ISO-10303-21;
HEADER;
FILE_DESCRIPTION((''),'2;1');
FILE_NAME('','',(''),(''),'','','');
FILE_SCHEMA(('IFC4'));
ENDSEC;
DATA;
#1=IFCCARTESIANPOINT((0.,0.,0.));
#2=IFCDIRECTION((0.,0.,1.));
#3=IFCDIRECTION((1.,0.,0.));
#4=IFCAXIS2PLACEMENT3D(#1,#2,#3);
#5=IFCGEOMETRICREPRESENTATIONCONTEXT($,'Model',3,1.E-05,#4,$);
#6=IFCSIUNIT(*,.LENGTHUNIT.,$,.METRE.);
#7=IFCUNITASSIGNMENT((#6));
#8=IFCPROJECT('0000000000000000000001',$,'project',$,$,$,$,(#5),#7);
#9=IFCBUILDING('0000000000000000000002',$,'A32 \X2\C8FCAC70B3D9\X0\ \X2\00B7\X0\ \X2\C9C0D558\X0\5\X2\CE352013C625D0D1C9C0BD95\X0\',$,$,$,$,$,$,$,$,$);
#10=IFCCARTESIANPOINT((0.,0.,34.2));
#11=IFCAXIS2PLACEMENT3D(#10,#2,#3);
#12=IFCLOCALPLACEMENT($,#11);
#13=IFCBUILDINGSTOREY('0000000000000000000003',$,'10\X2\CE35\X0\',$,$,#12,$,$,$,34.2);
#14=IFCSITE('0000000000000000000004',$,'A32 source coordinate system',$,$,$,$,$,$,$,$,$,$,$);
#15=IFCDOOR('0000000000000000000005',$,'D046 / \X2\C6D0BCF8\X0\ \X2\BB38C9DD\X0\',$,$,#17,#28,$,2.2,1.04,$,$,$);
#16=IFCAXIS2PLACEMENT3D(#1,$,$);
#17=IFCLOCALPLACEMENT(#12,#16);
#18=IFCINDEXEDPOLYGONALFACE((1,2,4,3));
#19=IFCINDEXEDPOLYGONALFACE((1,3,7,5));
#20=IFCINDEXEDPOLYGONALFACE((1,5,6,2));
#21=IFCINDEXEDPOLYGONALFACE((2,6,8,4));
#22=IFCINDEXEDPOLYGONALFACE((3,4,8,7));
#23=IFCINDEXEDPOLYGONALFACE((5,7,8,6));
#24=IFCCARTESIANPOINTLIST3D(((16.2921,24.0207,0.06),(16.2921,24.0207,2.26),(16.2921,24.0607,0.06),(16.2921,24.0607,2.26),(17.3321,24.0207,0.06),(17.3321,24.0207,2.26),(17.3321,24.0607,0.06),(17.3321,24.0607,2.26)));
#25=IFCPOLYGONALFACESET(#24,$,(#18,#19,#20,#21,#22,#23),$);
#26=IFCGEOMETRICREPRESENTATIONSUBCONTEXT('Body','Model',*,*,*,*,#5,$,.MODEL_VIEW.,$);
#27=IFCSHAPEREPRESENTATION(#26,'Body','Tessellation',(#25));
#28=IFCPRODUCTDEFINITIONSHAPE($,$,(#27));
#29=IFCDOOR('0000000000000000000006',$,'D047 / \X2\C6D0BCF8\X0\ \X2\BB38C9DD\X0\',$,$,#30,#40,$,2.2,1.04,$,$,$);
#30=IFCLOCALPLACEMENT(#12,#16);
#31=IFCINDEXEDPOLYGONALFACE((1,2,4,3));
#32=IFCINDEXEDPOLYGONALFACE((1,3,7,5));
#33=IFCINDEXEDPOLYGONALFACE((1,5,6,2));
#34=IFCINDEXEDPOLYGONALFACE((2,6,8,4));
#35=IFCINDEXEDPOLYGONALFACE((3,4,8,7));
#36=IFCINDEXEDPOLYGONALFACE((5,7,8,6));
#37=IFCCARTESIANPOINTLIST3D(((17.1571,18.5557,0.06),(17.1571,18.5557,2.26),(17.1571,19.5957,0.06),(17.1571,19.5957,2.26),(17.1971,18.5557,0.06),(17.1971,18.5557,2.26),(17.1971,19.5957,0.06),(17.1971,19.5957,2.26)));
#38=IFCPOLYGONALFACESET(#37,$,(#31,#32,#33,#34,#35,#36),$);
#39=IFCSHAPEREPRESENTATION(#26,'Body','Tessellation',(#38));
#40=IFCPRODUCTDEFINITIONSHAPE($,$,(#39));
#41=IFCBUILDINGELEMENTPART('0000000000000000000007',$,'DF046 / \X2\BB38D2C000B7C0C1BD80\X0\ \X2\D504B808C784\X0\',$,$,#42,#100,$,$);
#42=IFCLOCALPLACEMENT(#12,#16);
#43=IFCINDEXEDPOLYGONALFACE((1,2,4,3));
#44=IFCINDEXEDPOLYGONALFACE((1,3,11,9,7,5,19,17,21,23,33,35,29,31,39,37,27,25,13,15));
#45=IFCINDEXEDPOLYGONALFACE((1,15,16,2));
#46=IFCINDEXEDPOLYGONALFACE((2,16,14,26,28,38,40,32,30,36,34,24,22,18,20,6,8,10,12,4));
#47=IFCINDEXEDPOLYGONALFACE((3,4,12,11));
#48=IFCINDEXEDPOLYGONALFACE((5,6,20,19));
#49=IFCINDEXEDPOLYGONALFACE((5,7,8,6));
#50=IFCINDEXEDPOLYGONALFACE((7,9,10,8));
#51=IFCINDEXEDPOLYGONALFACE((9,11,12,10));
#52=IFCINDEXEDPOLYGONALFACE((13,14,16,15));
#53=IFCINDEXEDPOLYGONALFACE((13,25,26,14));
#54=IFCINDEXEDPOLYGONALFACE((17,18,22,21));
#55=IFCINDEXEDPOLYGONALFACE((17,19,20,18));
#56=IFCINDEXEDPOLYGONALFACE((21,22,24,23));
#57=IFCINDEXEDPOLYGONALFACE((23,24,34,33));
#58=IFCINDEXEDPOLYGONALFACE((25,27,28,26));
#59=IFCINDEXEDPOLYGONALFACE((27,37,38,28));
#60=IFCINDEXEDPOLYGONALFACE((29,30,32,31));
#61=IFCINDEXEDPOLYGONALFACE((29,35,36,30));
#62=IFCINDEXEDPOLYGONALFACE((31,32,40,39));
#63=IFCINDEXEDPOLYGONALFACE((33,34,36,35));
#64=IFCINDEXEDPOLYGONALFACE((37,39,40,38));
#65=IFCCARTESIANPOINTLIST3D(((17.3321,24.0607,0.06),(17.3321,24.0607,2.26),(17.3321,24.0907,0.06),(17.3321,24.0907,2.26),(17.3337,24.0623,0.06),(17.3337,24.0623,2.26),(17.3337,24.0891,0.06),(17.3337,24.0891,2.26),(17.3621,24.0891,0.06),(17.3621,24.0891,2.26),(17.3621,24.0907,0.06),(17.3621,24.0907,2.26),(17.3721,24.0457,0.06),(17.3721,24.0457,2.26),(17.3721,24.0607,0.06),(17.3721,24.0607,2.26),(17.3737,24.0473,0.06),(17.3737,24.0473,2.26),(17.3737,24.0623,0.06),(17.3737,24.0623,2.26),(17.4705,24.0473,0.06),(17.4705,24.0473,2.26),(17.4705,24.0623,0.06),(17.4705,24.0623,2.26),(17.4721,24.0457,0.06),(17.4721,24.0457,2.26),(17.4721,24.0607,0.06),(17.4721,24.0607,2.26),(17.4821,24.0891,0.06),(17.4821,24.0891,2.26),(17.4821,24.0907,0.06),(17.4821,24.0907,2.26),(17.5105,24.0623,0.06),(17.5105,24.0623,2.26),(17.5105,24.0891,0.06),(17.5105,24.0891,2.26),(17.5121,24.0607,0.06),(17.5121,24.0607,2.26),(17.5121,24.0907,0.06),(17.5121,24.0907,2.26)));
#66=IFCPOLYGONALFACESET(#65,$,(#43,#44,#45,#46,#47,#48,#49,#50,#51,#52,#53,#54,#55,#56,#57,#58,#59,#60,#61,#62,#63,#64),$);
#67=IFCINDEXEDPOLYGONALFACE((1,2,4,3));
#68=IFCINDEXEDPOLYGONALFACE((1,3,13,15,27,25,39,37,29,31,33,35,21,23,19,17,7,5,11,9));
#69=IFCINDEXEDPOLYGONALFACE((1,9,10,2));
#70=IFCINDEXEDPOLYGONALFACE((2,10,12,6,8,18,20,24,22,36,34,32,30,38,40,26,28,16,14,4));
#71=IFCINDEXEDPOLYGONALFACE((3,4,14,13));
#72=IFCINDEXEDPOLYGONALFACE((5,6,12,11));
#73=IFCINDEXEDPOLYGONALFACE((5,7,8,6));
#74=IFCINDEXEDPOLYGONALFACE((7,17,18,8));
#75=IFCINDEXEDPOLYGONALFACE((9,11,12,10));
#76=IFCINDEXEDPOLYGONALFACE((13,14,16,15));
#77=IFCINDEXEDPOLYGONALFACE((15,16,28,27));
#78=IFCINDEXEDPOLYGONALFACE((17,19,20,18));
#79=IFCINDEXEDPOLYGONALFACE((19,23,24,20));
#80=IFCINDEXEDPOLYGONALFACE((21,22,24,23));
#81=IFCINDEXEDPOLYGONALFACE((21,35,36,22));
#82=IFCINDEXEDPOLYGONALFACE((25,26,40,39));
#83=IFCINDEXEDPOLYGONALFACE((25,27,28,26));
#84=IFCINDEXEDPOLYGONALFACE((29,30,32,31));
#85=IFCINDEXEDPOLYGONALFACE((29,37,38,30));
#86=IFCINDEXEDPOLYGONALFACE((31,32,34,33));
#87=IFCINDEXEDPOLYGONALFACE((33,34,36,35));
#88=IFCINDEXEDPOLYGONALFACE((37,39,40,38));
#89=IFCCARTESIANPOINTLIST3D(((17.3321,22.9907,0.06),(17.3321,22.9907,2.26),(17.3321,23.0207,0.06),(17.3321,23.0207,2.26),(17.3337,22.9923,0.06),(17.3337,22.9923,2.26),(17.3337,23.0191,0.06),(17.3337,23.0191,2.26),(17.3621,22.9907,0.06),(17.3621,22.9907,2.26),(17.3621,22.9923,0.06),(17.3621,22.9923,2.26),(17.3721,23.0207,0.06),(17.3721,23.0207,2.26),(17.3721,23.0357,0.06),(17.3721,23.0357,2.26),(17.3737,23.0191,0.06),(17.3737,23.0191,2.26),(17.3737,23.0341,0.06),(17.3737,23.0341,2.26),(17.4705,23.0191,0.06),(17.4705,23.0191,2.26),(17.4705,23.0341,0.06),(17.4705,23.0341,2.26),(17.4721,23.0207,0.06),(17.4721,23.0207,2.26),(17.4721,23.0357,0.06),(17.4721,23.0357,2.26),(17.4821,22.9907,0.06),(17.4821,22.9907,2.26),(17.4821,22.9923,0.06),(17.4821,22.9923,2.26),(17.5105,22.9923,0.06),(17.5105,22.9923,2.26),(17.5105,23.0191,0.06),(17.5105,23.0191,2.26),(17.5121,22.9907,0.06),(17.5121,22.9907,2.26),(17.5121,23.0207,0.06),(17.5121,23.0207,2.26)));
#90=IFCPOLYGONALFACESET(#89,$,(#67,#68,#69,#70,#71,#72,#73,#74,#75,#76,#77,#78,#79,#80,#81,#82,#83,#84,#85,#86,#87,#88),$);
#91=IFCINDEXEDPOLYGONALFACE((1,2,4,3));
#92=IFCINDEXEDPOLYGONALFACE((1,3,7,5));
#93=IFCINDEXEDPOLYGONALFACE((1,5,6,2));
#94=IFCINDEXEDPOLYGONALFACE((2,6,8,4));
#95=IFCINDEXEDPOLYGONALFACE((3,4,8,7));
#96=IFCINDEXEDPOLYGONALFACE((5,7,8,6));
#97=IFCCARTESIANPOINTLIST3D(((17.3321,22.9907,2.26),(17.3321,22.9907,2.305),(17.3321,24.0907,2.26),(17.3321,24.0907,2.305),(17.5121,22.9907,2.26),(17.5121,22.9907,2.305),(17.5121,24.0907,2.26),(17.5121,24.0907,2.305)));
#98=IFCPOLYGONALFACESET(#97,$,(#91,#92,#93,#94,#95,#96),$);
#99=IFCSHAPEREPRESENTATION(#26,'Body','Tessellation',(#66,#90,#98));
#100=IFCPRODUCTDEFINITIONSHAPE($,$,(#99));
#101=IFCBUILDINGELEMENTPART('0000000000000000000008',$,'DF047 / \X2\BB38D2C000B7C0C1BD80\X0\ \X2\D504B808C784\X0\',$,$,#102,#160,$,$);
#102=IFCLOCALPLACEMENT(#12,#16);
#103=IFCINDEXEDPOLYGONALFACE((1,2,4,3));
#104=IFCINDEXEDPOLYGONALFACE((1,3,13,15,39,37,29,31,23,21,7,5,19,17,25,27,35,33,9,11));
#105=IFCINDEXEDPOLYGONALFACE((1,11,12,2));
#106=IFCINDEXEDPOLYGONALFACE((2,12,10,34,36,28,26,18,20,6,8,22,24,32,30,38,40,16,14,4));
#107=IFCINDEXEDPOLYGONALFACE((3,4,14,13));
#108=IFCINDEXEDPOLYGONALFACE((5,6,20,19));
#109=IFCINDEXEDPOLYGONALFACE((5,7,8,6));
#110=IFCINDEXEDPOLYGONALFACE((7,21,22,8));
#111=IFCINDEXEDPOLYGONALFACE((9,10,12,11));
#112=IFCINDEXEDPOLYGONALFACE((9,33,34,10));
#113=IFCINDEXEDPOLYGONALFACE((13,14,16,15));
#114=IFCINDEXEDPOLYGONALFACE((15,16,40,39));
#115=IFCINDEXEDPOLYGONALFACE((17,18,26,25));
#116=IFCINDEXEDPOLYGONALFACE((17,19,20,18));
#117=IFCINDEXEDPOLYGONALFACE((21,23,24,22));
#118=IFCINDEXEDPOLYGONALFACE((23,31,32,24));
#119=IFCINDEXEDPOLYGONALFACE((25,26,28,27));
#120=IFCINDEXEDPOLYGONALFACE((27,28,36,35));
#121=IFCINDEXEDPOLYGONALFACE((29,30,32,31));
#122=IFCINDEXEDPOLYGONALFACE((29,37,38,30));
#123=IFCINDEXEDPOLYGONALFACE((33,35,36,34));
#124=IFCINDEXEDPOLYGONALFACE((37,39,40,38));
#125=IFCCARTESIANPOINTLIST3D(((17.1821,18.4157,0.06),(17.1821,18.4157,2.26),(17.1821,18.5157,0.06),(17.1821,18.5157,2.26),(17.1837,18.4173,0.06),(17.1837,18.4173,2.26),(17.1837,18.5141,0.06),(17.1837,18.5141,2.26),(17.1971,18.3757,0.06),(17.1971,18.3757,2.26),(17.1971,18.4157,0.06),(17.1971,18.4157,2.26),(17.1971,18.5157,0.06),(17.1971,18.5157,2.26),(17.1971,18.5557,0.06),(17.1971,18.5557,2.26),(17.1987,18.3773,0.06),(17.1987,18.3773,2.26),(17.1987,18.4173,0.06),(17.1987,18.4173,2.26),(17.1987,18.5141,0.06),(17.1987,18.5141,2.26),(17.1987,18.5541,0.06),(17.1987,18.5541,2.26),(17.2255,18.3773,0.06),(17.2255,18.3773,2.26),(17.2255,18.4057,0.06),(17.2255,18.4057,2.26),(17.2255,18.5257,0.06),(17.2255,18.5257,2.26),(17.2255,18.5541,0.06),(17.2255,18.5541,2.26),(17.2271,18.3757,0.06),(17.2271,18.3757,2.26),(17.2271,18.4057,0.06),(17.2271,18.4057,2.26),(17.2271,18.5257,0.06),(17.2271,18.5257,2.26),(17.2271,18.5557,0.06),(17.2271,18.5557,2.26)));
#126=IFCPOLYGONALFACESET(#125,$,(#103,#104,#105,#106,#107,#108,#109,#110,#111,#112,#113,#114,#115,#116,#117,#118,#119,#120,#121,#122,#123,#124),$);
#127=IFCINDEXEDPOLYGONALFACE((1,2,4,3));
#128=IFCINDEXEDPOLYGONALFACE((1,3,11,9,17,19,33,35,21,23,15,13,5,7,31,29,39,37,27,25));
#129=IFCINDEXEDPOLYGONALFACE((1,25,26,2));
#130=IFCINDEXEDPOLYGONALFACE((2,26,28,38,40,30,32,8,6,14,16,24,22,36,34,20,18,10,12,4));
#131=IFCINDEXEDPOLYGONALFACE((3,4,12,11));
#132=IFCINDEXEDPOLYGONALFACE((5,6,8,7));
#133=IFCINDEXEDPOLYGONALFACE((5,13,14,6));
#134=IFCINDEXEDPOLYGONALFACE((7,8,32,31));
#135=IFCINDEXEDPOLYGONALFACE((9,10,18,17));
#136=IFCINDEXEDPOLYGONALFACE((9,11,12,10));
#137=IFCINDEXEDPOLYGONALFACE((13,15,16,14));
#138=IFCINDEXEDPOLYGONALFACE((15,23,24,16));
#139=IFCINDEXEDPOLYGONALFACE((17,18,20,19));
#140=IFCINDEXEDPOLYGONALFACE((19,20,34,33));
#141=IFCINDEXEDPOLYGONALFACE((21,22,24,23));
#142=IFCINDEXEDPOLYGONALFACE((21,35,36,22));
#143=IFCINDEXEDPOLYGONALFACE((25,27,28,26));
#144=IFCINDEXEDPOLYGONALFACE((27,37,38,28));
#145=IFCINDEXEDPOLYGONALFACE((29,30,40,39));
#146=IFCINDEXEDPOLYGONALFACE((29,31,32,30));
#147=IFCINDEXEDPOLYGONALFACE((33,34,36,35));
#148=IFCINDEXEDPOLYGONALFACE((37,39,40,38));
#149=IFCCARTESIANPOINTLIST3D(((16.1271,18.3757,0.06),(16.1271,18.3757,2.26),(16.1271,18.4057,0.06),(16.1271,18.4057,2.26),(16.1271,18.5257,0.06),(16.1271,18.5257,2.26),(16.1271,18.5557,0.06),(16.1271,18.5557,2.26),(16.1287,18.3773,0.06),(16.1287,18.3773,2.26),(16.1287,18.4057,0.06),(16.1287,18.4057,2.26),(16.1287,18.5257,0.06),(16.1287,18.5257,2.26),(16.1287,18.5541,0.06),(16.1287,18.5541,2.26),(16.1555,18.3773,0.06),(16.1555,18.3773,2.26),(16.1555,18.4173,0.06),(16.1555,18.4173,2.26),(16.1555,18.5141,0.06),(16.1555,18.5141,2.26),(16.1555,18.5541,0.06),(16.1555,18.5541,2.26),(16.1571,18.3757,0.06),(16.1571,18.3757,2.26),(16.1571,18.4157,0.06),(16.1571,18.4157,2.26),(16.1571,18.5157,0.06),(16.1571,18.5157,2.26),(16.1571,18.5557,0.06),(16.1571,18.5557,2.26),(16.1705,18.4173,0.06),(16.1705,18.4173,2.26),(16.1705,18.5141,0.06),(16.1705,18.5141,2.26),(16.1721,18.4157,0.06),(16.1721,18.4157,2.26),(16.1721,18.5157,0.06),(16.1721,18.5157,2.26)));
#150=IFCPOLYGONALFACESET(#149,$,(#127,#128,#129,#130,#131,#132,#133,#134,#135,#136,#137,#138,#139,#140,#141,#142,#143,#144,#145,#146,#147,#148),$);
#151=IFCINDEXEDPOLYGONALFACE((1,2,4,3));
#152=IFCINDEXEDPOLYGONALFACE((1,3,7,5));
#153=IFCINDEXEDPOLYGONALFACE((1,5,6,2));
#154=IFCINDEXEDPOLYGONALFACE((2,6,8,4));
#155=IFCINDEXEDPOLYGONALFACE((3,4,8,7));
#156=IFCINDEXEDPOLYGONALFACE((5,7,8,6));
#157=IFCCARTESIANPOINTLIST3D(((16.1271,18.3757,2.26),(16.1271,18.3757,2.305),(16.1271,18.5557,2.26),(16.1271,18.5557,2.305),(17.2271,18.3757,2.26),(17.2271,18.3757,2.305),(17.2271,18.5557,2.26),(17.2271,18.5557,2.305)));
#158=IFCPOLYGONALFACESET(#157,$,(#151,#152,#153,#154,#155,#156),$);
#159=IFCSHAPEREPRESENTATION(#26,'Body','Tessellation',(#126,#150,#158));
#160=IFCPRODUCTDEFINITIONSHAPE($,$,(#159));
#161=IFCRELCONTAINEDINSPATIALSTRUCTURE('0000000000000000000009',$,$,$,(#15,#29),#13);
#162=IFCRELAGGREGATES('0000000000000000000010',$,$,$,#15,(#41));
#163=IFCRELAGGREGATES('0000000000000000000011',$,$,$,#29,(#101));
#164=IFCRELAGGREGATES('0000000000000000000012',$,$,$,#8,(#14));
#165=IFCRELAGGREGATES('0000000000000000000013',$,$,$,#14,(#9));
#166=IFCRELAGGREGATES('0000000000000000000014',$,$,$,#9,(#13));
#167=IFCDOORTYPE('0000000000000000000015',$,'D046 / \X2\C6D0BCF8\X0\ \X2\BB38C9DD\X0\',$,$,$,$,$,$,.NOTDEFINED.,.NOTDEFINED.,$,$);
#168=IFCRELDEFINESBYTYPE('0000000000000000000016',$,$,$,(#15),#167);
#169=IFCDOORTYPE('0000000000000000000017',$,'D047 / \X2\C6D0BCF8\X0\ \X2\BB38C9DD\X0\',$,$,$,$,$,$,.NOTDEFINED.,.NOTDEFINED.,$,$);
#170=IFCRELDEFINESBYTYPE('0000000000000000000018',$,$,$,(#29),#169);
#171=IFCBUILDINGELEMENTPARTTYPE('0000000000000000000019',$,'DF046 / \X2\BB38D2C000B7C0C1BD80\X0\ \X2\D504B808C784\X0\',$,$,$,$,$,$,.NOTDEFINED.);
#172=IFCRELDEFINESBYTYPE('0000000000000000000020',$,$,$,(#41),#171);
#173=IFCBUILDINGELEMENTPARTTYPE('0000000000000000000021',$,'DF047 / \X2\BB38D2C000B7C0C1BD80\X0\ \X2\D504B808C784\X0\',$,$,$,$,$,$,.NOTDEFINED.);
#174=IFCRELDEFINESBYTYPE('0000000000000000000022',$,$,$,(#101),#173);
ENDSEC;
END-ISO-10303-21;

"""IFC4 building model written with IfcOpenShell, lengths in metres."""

from ifc_helpers import new_model, si_unit, frame, origin, origin_with_axes, place, context, subcontext, project, spatial, polyline, outline, extrude, source, transform, mapped, type_object, type_shapes, element, aggregate, save


model = new_model("IFC4")

# Units and contexts
model_context = context("Model", 3, precision=1e-05, world=origin_with_axes())
body_context = subcontext(model_context, "Body", "Model", "MODEL_VIEW")
ifc_project = project(units=[si_unit("LENGTHUNIT", "METRE")], contexts=[model_context])

# Site, building, storey
storey_placement = place(None, frame((0.0, 0.0, 34.2), z_axis=(0.0, 0.0, 1.0), x_axis=(1.0, 0.0, 0.0)))
site = spatial("IfcSite", under=ifc_project, Name="A32 source coordinate system")
building = spatial("IfcBuilding", under=site, Name="A32 주거동 · 지하5층–옥탑지붕")
storey = spatial("IfcBuildingStorey", under=building, at=storey_placement, Name="10층", Elevation=34.2)

# Doors
door_type_1 = type_object("IfcDoorType", Name="D046 / 원본 문짝", OperationType="NOTDEFINED", PredefinedType="NOTDEFINED")
shared_shape_1 = source(origin(), body_context, "Body", "SweptSolid", [
    extrude(outline(polyline([(17.3321, 24.0607), (17.3321, 24.0207), (16.2921, 24.0207), (16.2921, 24.0607), (17.3321, 24.0607)])), frame((0.0, 0.0, 0.06)), (0.0, 0.0, 1.0), 2.2),
])
type_shapes(door_type_1, [shared_shape_1])
door_1_placement = place(storey_placement, origin_with_axes())
door_1 = element("IfcDoor", 1, at=door_1_placement, inside=storey, type_object=door_type_1, Name="D046 / 원본 문짝", OverallHeight=2.2, OverallWidth=1.04, context=body_context, shape_type="MappedRepresentation", body=[
    mapped(shared_shape_1, transform((0.0, 0.0, 0.0), scale=1.0)),
])
door_type_2 = type_object("IfcDoorType", Name="D047 / 원본 문짝", OperationType="NOTDEFINED", PredefinedType="NOTDEFINED")
shared_shape_2 = source(origin(), body_context, "Body", "SweptSolid", [
    extrude(outline(polyline([(17.1971, 18.5557), (17.1571, 18.5557), (17.1571, 19.5957), (17.1971, 19.5957), (17.1971, 18.5557)])), frame((0.0, 0.0, 0.06)), (0.0, 0.0, 1.0), 2.2),
])
type_shapes(door_type_2, [shared_shape_2])
door_2_placement = place(storey_placement, origin_with_axes())
door_2 = element("IfcDoor", 2, at=door_2_placement, inside=storey, type_object=door_type_2, Name="D047 / 원본 문짝", OverallHeight=2.2, OverallWidth=1.04, context=body_context, shape_type="MappedRepresentation", body=[
    mapped(shared_shape_2, transform((0.0, 0.0, 0.0), scale=1.0)),
])

# Building element parts
building_element_part_type_1 = type_object("IfcBuildingElementPartType", Name="DF046 / 문틀·상부 프레임", PredefinedType="NOTDEFINED")
shared_shape_3 = source(origin(), body_context, "Body", "SweptSolid", [
    extrude(outline(polyline([(17.3337, 24.0891), (17.3337, 24.0623), (17.3737, 24.0623), (17.3737, 24.0473), (17.4705, 24.0473), (17.4705, 24.0623), (17.5105, 24.0623), (17.5105, 24.0891), (17.4821, 24.0891), (17.4821, 24.0907), (17.5121, 24.0907), (17.5121, 24.0607), (17.4721, 24.0607), (17.4721, 24.0457), (17.3721, 24.0457), (17.3721, 24.0607), (17.3321, 24.0607), (17.3321, 24.0907), (17.3621, 24.0907), (17.3621, 24.0891), (17.3337, 24.0891)])), frame((0.0, 0.0, 0.06)), (0.0, 0.0, 1.0), 2.2),
    extrude(outline(polyline([(17.3621, 22.9907), (17.3321, 22.9907), (17.3321, 23.0207), (17.3721, 23.0207), (17.3721, 23.0357), (17.4721, 23.0357), (17.4721, 23.0207), (17.5121, 23.0207), (17.5121, 22.9907), (17.4821, 22.9907), (17.4821, 22.9923), (17.5105, 22.9923), (17.5105, 23.0191), (17.4705, 23.0191), (17.4705, 23.0341), (17.3737, 23.0341), (17.3737, 23.0191), (17.3337, 23.0191), (17.3337, 22.9923), (17.3621, 22.9923), (17.3621, 22.9907)])), frame((0.0, 0.0, 0.06)), (0.0, 0.0, 1.0), 2.2),
    extrude(outline(polyline([(17.3321, 22.9907), (17.3321, 24.0907), (17.5121, 24.0907), (17.5121, 22.9907), (17.3321, 22.9907)])), frame((0.0, 0.0, 2.26)), (0.0, 0.0, 1.0), 0.045),
])
type_shapes(building_element_part_type_1, [shared_shape_3])
building_element_part_1_placement = place(door_1_placement, origin_with_axes())
building_element_part_1 = element("IfcBuildingElementPart", 3, at=building_element_part_1_placement, type_object=building_element_part_type_1, Name="DF046 / 문틀·상부 프레임", context=body_context, shape_type="MappedRepresentation", body=[
    mapped(shared_shape_3, transform((0.0, 0.0, 0.0), scale=1.0)),
])
aggregate(door_1, [building_element_part_1])
building_element_part_type_2 = type_object("IfcBuildingElementPartType", Name="DF047 / 문틀·상부 프레임", PredefinedType="NOTDEFINED")
shared_shape_4 = source(origin(), body_context, "Body", "SweptSolid", [
    extrude(outline(polyline([(17.2255, 18.5541), (17.1987, 18.5541), (17.1987, 18.5141), (17.1837, 18.5141), (17.1837, 18.4173), (17.1987, 18.4173), (17.1987, 18.3773), (17.2255, 18.3773), (17.2255, 18.4057), (17.2271, 18.4057), (17.2271, 18.3757), (17.1971, 18.3757), (17.1971, 18.4157), (17.1821, 18.4157), (17.1821, 18.5157), (17.1971, 18.5157), (17.1971, 18.5557), (17.2271, 18.5557), (17.2271, 18.5257), (17.2255, 18.5257), (17.2255, 18.5541)])), frame((0.0, 0.0, 0.06)), (0.0, 0.0, 1.0), 2.2),
    extrude(outline(polyline([(16.1271, 18.5257), (16.1271, 18.5557), (16.1571, 18.5557), (16.1571, 18.5157), (16.1721, 18.5157), (16.1721, 18.4157), (16.1571, 18.4157), (16.1571, 18.3757), (16.1271, 18.3757), (16.1271, 18.4057), (16.1287, 18.4057), (16.1287, 18.3773), (16.1555, 18.3773), (16.1555, 18.4173), (16.1705, 18.4173), (16.1705, 18.5141), (16.1555, 18.5141), (16.1555, 18.5541), (16.1287, 18.5541), (16.1287, 18.5257), (16.1271, 18.5257)])), frame((0.0, 0.0, 0.06)), (0.0, 0.0, 1.0), 2.2),
    extrude(outline(polyline([(16.1271, 18.3757), (16.1271, 18.5557), (17.2271, 18.5557), (17.2271, 18.3757), (16.1271, 18.3757)])), frame((0.0, 0.0, 2.26)), (0.0, 0.0, 1.0), 0.045),
])
type_shapes(building_element_part_type_2, [shared_shape_4])
building_element_part_2_placement = place(door_2_placement, origin_with_axes())
building_element_part_2 = element("IfcBuildingElementPart", 4, at=building_element_part_2_placement, type_object=building_element_part_type_2, Name="DF047 / 문틀·상부 프레임", context=body_context, shape_type="MappedRepresentation", body=[
    mapped(shared_shape_4, transform((0.0, 0.0, 0.0), scale=1.0)),
])
aggregate(door_2, [building_element_part_2])

save(model, "model.ifc")
